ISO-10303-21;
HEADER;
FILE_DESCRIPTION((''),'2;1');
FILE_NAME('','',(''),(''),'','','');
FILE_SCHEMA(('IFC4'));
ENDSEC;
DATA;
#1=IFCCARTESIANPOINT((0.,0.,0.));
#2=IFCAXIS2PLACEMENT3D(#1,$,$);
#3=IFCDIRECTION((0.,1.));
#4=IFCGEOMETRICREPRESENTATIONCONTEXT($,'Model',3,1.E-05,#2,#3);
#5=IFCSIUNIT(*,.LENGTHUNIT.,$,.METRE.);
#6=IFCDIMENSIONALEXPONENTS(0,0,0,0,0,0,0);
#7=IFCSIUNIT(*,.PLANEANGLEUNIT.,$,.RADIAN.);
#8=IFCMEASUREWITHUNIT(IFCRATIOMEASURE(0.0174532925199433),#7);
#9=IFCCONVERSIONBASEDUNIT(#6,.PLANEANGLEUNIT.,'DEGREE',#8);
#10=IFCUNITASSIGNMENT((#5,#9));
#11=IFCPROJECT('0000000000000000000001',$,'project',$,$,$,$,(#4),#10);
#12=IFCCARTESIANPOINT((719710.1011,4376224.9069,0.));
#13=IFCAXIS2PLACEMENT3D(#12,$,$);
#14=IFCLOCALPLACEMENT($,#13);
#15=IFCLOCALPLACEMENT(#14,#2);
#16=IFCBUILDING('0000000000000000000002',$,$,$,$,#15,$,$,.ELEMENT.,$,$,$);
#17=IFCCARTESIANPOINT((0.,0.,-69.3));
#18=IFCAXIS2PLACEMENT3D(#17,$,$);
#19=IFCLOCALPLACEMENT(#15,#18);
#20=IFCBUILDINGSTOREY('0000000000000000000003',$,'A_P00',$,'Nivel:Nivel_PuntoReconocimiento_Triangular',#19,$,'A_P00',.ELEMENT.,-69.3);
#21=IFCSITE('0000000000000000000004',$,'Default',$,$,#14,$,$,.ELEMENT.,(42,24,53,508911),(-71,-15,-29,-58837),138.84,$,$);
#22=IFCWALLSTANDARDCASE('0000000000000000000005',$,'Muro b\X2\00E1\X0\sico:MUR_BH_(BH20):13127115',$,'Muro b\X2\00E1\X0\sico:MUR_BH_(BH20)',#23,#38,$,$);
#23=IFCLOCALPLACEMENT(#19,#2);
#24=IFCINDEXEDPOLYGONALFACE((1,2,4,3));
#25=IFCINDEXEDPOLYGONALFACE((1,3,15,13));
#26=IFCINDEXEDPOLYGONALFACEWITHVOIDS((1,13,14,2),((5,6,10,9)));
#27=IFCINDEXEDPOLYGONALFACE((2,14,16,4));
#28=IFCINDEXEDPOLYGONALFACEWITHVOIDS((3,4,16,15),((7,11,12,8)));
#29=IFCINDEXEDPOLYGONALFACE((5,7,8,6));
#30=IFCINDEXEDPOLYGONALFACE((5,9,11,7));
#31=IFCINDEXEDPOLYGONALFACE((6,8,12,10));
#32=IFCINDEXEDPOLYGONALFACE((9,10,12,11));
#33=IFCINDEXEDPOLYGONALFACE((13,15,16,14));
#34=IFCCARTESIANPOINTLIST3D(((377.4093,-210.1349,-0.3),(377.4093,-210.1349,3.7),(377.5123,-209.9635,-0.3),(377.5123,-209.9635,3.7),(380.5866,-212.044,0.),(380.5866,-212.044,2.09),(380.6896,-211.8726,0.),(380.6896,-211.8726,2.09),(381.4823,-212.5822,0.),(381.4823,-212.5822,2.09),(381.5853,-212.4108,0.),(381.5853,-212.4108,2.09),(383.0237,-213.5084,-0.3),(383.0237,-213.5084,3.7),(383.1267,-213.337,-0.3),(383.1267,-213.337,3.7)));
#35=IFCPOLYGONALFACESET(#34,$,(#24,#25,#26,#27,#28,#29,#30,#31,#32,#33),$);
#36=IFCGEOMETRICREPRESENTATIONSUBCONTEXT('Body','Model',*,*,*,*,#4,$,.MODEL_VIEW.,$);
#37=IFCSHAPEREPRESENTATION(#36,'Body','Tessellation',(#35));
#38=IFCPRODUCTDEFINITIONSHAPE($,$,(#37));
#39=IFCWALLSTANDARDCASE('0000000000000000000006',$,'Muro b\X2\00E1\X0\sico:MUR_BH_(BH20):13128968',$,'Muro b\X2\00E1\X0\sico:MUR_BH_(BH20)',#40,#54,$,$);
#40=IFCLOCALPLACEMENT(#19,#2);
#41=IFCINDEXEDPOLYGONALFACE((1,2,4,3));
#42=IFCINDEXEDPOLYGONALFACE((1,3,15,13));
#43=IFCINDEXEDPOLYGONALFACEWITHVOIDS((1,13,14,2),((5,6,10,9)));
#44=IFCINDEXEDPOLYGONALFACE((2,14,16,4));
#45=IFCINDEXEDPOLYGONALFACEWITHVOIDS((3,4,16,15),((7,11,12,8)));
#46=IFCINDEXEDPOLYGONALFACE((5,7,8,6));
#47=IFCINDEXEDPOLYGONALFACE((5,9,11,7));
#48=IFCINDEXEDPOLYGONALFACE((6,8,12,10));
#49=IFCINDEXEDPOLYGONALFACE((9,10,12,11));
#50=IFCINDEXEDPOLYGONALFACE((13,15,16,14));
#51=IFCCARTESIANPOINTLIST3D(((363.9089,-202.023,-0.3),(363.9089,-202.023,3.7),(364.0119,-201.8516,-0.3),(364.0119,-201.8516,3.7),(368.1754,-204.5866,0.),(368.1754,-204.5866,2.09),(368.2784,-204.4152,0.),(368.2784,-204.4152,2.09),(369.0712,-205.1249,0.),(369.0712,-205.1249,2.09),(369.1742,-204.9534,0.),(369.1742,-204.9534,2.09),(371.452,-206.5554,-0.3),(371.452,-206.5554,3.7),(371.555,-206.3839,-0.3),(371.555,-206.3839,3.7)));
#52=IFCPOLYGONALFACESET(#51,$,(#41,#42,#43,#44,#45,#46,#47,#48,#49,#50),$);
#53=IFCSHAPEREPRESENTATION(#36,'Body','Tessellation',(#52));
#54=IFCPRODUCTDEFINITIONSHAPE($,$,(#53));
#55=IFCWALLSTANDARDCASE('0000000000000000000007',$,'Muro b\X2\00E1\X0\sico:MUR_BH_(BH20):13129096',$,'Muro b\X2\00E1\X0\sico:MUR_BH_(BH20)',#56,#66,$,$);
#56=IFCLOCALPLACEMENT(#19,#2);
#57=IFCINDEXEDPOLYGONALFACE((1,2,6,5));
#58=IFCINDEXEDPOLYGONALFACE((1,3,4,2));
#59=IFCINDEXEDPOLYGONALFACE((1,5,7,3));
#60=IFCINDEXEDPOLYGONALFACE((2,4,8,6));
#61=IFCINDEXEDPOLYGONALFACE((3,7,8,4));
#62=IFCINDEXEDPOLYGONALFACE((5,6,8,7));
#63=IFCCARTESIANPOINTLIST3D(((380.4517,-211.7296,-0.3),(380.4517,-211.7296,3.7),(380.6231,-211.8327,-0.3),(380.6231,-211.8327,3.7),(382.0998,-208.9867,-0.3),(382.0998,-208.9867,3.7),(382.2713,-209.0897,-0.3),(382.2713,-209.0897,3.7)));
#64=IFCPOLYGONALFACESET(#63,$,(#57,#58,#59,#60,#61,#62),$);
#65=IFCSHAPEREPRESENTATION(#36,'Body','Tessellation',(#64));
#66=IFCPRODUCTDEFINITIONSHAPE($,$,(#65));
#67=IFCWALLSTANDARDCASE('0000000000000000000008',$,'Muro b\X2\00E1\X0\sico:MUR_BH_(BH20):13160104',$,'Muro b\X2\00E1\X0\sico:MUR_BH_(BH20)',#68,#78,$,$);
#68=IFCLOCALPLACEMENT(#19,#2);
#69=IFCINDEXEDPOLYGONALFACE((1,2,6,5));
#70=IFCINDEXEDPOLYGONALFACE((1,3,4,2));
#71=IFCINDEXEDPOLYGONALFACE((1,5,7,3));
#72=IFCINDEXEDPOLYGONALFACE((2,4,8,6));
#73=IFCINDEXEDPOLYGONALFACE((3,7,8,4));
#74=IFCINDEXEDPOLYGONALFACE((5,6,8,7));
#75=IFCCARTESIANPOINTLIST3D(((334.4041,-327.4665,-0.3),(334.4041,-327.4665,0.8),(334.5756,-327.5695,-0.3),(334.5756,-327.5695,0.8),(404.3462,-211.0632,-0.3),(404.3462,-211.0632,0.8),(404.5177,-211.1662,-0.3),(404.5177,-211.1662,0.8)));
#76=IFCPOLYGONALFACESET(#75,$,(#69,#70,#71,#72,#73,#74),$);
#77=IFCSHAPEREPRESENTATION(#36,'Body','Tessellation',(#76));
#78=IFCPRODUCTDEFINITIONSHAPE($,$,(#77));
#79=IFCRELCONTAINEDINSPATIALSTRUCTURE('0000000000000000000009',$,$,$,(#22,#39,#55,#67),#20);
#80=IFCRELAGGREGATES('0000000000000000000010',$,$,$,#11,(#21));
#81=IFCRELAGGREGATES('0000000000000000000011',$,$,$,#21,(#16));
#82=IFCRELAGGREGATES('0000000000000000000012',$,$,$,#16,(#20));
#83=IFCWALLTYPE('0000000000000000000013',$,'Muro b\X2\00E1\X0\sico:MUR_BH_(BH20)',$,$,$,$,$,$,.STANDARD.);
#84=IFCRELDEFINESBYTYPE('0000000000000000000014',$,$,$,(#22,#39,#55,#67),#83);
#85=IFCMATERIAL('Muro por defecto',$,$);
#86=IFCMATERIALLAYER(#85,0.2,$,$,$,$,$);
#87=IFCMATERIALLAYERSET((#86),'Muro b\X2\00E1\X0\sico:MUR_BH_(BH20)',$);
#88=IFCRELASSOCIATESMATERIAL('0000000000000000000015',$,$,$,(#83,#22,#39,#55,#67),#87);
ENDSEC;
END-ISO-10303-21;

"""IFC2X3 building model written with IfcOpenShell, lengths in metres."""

from ifc_helpers import new_model, entity, si_unit, converted_unit, direction, frame, frame_2d, origin, place, context, subcontext, project, spatial, rectangle, extrude, material, layer, layer_set, layer_usage, type_object, element, save


model = new_model("IFC2X3")

# Units and contexts
model_context = context("Model", 3, precision=1e-05, world=origin(), true_north=direction((0.0, 1.0)))
body_context = subcontext(model_context, "Body", "Model", "MODEL_VIEW")
ifc_project = project(units=[si_unit("LENGTHUNIT", "METRE"), converted_unit("PLANEANGLEUNIT", "DEGREE", entity("IfcRatioMeasure", 0.0174532925199433), si_unit("PLANEANGLEUNIT", "RADIAN"), dimensions=[0, 0, 0, 0, 0, 0, 0])], contexts=[model_context])

# Site, building, storey
site_placement = place(None, frame((719710.1011, 4376224.9069, 0.0)))
site = spatial("IfcSite", under=ifc_project, at=site_placement, Name="Default", CompositionType="ELEMENT", RefLatitude=(42, 24, 53, 508911), RefLongitude=(-71, -15, -29, -58837), RefElevation=138.84)
building_placement = place(site_placement, origin())
building = spatial("IfcBuilding", under=site, at=building_placement, CompositionType="ELEMENT")
storey_placement = place(building_placement, frame((0.0, 0.0, -69.3)))
storey = spatial("IfcBuildingStorey", under=building, at=storey_placement, Name="A_P00", ObjectType="Nivel:Nivel_PuntoReconocimiento_Triangular", LongName="A_P00", CompositionType="ELEMENT", Elevation=-69.3)

# Shared definitions
ifc_material_1 = material(Name="Muro por defecto")
ifc_layer = layer(ifc_material_1, 0.2)
ifc_layer_set = layer_set([ifc_layer], Name="Muro básico:MUR_BH_(BH20)")
wall_type = type_object("IfcWallType", Name="Muro básico:MUR_BH_(BH20)", PredefinedType="STANDARD", material=ifc_layer_set)

# Walls, openings
ifc_layer_usage_1 = layer_usage(ifc_layer_set, "AXIS2", "NEGATIVE", 0.1)
wall_1_placement = place(storey_placement, frame((383.0752, -213.4227, -0.3), z_axis=(0.0, 0.0, 1.0), x_axis=(-0.857167, 0.515038, 0.0)))
wall_1 = element("IfcWallStandardCase", 1, at=wall_1_placement, inside=storey, type_object=wall_type, material=ifc_layer_usage_1, Name="Muro básico:MUR_BH_(BH20):13127115", ObjectType="Muro básico:MUR_BH_(BH20)", context=body_context, shape_type="SweptSolid", body=[
    extrude(rectangle(XDim=6.55, YDim=0.2, at=frame_2d((3.275, 0.0), x_axis=(-1.0, 0.0))), origin(), (0.0, 0.0, 1.0), 4.0),
])
opening_1_placement = place(wall_1_placement, frame((438.2804, 14.3594, 0.3), z_axis=(0.0, 0.0, 1.0), x_axis=(-0.857167, -0.515038, 0.0)))
element("IfcOpeningElement", 2, at=opening_1_placement, cuts=wall_1, ObjectType="Opening", context=body_context, shape_type="SweptSolid", body=[
    extrude(rectangle(XDim=2.09, YDim=1.045, at=frame_2d((0.0, 0.0), x_axis=(1.0, 0.0))), frame((381.1374, -212.1417, 1.045), z_axis=(-0.515038, -0.857167, 0.0), x_axis=(0.0, 0.0, -1.0)), (0.0, 0.0, 1.0), 0.2),
])
ifc_layer_usage_2 = layer_usage(ifc_layer_set, "AXIS2", "NEGATIVE", 0.1)
wall_2_placement = place(storey_placement, frame((371.5035, -206.4697, -0.3), z_axis=(0.0, 0.0, 1.0), x_axis=(-0.857167, 0.515038, 0.0)))
wall_2 = element("IfcWallStandardCase", 3, at=wall_2_placement, inside=storey, type_object=wall_type, material=ifc_layer_usage_2, Name="Muro básico:MUR_BH_(BH20):13128968", ObjectType="Muro básico:MUR_BH_(BH20)", context=body_context, shape_type="SweptSolid", body=[
    extrude(rectangle(XDim=8.8, YDim=0.2, at=frame_2d((4.4, 0.0), x_axis=(-1.0, 0.0))), origin(), (0.0, 0.0, 1.0), 4.0),
])
opening_2_placement = place(wall_2_placement, frame((424.7804, 14.3594, 0.3), z_axis=(0.0, 0.0, 1.0), x_axis=(-0.857167, -0.515038, 0.0)))
element("IfcOpeningElement", 4, at=opening_2_placement, cuts=wall_2, ObjectType="Opening", context=body_context, shape_type="SweptSolid", body=[
    extrude(rectangle(XDim=2.09, YDim=1.045, at=frame_2d((0.0, 0.0), x_axis=(1.0, 0.0))), frame((368.7263, -204.6843, 1.045), z_axis=(-0.515038, -0.857167, 0.0), x_axis=(0.0, 0.0, -1.0)), (0.0, 0.0, 1.0), 0.2),
])

# Walls
ifc_layer_usage_3 = layer_usage(ifc_layer_set, "AXIS2", "NEGATIVE", 0.1)
wall_3_placement = place(storey_placement, frame((380.5374, -211.7812, -0.3), z_axis=(0.0, 0.0, 1.0), x_axis=(0.515038, 0.857167, 0.0)))
element("IfcWallStandardCase", 5, at=wall_3_placement, inside=storey, type_object=wall_type, material=ifc_layer_usage_3, Name="Muro básico:MUR_BH_(BH20):13129096", ObjectType="Muro básico:MUR_BH_(BH20)", context=body_context, shape_type="SweptSolid", body=[
    extrude(rectangle(XDim=3.2, YDim=0.2, at=frame_2d((1.6, 0.0), x_axis=(-1.0, 0.0))), origin(), (0.0, 0.0, 1.0), 4.0),
])
ifc_layer_usage_4 = layer_usage(ifc_layer_set, "AXIS2", "NEGATIVE", 0.1)
wall_4_placement = place(storey_placement, frame((404.432, -211.1147, -0.3), z_axis=(0.0, 0.0, 1.0), x_axis=(-0.515038, -0.857167, 0.0)))
element("IfcWallStandardCase", 6, at=wall_4_placement, inside=storey, type_object=wall_type, material=ifc_layer_usage_4, Name="Muro básico:MUR_BH_(BH20):13160104", ObjectType="Muro básico:MUR_BH_(BH20)", context=body_context, shape_type="SweptSolid", body=[
    extrude(rectangle(XDim=135.7999, YDim=0.2, at=frame_2d((67.9, 0.0), x_axis=(-1.0, 0.0))), origin(), (0.0, 0.0, 1.0), 1.1),
])

save(model, "model.ifc")
